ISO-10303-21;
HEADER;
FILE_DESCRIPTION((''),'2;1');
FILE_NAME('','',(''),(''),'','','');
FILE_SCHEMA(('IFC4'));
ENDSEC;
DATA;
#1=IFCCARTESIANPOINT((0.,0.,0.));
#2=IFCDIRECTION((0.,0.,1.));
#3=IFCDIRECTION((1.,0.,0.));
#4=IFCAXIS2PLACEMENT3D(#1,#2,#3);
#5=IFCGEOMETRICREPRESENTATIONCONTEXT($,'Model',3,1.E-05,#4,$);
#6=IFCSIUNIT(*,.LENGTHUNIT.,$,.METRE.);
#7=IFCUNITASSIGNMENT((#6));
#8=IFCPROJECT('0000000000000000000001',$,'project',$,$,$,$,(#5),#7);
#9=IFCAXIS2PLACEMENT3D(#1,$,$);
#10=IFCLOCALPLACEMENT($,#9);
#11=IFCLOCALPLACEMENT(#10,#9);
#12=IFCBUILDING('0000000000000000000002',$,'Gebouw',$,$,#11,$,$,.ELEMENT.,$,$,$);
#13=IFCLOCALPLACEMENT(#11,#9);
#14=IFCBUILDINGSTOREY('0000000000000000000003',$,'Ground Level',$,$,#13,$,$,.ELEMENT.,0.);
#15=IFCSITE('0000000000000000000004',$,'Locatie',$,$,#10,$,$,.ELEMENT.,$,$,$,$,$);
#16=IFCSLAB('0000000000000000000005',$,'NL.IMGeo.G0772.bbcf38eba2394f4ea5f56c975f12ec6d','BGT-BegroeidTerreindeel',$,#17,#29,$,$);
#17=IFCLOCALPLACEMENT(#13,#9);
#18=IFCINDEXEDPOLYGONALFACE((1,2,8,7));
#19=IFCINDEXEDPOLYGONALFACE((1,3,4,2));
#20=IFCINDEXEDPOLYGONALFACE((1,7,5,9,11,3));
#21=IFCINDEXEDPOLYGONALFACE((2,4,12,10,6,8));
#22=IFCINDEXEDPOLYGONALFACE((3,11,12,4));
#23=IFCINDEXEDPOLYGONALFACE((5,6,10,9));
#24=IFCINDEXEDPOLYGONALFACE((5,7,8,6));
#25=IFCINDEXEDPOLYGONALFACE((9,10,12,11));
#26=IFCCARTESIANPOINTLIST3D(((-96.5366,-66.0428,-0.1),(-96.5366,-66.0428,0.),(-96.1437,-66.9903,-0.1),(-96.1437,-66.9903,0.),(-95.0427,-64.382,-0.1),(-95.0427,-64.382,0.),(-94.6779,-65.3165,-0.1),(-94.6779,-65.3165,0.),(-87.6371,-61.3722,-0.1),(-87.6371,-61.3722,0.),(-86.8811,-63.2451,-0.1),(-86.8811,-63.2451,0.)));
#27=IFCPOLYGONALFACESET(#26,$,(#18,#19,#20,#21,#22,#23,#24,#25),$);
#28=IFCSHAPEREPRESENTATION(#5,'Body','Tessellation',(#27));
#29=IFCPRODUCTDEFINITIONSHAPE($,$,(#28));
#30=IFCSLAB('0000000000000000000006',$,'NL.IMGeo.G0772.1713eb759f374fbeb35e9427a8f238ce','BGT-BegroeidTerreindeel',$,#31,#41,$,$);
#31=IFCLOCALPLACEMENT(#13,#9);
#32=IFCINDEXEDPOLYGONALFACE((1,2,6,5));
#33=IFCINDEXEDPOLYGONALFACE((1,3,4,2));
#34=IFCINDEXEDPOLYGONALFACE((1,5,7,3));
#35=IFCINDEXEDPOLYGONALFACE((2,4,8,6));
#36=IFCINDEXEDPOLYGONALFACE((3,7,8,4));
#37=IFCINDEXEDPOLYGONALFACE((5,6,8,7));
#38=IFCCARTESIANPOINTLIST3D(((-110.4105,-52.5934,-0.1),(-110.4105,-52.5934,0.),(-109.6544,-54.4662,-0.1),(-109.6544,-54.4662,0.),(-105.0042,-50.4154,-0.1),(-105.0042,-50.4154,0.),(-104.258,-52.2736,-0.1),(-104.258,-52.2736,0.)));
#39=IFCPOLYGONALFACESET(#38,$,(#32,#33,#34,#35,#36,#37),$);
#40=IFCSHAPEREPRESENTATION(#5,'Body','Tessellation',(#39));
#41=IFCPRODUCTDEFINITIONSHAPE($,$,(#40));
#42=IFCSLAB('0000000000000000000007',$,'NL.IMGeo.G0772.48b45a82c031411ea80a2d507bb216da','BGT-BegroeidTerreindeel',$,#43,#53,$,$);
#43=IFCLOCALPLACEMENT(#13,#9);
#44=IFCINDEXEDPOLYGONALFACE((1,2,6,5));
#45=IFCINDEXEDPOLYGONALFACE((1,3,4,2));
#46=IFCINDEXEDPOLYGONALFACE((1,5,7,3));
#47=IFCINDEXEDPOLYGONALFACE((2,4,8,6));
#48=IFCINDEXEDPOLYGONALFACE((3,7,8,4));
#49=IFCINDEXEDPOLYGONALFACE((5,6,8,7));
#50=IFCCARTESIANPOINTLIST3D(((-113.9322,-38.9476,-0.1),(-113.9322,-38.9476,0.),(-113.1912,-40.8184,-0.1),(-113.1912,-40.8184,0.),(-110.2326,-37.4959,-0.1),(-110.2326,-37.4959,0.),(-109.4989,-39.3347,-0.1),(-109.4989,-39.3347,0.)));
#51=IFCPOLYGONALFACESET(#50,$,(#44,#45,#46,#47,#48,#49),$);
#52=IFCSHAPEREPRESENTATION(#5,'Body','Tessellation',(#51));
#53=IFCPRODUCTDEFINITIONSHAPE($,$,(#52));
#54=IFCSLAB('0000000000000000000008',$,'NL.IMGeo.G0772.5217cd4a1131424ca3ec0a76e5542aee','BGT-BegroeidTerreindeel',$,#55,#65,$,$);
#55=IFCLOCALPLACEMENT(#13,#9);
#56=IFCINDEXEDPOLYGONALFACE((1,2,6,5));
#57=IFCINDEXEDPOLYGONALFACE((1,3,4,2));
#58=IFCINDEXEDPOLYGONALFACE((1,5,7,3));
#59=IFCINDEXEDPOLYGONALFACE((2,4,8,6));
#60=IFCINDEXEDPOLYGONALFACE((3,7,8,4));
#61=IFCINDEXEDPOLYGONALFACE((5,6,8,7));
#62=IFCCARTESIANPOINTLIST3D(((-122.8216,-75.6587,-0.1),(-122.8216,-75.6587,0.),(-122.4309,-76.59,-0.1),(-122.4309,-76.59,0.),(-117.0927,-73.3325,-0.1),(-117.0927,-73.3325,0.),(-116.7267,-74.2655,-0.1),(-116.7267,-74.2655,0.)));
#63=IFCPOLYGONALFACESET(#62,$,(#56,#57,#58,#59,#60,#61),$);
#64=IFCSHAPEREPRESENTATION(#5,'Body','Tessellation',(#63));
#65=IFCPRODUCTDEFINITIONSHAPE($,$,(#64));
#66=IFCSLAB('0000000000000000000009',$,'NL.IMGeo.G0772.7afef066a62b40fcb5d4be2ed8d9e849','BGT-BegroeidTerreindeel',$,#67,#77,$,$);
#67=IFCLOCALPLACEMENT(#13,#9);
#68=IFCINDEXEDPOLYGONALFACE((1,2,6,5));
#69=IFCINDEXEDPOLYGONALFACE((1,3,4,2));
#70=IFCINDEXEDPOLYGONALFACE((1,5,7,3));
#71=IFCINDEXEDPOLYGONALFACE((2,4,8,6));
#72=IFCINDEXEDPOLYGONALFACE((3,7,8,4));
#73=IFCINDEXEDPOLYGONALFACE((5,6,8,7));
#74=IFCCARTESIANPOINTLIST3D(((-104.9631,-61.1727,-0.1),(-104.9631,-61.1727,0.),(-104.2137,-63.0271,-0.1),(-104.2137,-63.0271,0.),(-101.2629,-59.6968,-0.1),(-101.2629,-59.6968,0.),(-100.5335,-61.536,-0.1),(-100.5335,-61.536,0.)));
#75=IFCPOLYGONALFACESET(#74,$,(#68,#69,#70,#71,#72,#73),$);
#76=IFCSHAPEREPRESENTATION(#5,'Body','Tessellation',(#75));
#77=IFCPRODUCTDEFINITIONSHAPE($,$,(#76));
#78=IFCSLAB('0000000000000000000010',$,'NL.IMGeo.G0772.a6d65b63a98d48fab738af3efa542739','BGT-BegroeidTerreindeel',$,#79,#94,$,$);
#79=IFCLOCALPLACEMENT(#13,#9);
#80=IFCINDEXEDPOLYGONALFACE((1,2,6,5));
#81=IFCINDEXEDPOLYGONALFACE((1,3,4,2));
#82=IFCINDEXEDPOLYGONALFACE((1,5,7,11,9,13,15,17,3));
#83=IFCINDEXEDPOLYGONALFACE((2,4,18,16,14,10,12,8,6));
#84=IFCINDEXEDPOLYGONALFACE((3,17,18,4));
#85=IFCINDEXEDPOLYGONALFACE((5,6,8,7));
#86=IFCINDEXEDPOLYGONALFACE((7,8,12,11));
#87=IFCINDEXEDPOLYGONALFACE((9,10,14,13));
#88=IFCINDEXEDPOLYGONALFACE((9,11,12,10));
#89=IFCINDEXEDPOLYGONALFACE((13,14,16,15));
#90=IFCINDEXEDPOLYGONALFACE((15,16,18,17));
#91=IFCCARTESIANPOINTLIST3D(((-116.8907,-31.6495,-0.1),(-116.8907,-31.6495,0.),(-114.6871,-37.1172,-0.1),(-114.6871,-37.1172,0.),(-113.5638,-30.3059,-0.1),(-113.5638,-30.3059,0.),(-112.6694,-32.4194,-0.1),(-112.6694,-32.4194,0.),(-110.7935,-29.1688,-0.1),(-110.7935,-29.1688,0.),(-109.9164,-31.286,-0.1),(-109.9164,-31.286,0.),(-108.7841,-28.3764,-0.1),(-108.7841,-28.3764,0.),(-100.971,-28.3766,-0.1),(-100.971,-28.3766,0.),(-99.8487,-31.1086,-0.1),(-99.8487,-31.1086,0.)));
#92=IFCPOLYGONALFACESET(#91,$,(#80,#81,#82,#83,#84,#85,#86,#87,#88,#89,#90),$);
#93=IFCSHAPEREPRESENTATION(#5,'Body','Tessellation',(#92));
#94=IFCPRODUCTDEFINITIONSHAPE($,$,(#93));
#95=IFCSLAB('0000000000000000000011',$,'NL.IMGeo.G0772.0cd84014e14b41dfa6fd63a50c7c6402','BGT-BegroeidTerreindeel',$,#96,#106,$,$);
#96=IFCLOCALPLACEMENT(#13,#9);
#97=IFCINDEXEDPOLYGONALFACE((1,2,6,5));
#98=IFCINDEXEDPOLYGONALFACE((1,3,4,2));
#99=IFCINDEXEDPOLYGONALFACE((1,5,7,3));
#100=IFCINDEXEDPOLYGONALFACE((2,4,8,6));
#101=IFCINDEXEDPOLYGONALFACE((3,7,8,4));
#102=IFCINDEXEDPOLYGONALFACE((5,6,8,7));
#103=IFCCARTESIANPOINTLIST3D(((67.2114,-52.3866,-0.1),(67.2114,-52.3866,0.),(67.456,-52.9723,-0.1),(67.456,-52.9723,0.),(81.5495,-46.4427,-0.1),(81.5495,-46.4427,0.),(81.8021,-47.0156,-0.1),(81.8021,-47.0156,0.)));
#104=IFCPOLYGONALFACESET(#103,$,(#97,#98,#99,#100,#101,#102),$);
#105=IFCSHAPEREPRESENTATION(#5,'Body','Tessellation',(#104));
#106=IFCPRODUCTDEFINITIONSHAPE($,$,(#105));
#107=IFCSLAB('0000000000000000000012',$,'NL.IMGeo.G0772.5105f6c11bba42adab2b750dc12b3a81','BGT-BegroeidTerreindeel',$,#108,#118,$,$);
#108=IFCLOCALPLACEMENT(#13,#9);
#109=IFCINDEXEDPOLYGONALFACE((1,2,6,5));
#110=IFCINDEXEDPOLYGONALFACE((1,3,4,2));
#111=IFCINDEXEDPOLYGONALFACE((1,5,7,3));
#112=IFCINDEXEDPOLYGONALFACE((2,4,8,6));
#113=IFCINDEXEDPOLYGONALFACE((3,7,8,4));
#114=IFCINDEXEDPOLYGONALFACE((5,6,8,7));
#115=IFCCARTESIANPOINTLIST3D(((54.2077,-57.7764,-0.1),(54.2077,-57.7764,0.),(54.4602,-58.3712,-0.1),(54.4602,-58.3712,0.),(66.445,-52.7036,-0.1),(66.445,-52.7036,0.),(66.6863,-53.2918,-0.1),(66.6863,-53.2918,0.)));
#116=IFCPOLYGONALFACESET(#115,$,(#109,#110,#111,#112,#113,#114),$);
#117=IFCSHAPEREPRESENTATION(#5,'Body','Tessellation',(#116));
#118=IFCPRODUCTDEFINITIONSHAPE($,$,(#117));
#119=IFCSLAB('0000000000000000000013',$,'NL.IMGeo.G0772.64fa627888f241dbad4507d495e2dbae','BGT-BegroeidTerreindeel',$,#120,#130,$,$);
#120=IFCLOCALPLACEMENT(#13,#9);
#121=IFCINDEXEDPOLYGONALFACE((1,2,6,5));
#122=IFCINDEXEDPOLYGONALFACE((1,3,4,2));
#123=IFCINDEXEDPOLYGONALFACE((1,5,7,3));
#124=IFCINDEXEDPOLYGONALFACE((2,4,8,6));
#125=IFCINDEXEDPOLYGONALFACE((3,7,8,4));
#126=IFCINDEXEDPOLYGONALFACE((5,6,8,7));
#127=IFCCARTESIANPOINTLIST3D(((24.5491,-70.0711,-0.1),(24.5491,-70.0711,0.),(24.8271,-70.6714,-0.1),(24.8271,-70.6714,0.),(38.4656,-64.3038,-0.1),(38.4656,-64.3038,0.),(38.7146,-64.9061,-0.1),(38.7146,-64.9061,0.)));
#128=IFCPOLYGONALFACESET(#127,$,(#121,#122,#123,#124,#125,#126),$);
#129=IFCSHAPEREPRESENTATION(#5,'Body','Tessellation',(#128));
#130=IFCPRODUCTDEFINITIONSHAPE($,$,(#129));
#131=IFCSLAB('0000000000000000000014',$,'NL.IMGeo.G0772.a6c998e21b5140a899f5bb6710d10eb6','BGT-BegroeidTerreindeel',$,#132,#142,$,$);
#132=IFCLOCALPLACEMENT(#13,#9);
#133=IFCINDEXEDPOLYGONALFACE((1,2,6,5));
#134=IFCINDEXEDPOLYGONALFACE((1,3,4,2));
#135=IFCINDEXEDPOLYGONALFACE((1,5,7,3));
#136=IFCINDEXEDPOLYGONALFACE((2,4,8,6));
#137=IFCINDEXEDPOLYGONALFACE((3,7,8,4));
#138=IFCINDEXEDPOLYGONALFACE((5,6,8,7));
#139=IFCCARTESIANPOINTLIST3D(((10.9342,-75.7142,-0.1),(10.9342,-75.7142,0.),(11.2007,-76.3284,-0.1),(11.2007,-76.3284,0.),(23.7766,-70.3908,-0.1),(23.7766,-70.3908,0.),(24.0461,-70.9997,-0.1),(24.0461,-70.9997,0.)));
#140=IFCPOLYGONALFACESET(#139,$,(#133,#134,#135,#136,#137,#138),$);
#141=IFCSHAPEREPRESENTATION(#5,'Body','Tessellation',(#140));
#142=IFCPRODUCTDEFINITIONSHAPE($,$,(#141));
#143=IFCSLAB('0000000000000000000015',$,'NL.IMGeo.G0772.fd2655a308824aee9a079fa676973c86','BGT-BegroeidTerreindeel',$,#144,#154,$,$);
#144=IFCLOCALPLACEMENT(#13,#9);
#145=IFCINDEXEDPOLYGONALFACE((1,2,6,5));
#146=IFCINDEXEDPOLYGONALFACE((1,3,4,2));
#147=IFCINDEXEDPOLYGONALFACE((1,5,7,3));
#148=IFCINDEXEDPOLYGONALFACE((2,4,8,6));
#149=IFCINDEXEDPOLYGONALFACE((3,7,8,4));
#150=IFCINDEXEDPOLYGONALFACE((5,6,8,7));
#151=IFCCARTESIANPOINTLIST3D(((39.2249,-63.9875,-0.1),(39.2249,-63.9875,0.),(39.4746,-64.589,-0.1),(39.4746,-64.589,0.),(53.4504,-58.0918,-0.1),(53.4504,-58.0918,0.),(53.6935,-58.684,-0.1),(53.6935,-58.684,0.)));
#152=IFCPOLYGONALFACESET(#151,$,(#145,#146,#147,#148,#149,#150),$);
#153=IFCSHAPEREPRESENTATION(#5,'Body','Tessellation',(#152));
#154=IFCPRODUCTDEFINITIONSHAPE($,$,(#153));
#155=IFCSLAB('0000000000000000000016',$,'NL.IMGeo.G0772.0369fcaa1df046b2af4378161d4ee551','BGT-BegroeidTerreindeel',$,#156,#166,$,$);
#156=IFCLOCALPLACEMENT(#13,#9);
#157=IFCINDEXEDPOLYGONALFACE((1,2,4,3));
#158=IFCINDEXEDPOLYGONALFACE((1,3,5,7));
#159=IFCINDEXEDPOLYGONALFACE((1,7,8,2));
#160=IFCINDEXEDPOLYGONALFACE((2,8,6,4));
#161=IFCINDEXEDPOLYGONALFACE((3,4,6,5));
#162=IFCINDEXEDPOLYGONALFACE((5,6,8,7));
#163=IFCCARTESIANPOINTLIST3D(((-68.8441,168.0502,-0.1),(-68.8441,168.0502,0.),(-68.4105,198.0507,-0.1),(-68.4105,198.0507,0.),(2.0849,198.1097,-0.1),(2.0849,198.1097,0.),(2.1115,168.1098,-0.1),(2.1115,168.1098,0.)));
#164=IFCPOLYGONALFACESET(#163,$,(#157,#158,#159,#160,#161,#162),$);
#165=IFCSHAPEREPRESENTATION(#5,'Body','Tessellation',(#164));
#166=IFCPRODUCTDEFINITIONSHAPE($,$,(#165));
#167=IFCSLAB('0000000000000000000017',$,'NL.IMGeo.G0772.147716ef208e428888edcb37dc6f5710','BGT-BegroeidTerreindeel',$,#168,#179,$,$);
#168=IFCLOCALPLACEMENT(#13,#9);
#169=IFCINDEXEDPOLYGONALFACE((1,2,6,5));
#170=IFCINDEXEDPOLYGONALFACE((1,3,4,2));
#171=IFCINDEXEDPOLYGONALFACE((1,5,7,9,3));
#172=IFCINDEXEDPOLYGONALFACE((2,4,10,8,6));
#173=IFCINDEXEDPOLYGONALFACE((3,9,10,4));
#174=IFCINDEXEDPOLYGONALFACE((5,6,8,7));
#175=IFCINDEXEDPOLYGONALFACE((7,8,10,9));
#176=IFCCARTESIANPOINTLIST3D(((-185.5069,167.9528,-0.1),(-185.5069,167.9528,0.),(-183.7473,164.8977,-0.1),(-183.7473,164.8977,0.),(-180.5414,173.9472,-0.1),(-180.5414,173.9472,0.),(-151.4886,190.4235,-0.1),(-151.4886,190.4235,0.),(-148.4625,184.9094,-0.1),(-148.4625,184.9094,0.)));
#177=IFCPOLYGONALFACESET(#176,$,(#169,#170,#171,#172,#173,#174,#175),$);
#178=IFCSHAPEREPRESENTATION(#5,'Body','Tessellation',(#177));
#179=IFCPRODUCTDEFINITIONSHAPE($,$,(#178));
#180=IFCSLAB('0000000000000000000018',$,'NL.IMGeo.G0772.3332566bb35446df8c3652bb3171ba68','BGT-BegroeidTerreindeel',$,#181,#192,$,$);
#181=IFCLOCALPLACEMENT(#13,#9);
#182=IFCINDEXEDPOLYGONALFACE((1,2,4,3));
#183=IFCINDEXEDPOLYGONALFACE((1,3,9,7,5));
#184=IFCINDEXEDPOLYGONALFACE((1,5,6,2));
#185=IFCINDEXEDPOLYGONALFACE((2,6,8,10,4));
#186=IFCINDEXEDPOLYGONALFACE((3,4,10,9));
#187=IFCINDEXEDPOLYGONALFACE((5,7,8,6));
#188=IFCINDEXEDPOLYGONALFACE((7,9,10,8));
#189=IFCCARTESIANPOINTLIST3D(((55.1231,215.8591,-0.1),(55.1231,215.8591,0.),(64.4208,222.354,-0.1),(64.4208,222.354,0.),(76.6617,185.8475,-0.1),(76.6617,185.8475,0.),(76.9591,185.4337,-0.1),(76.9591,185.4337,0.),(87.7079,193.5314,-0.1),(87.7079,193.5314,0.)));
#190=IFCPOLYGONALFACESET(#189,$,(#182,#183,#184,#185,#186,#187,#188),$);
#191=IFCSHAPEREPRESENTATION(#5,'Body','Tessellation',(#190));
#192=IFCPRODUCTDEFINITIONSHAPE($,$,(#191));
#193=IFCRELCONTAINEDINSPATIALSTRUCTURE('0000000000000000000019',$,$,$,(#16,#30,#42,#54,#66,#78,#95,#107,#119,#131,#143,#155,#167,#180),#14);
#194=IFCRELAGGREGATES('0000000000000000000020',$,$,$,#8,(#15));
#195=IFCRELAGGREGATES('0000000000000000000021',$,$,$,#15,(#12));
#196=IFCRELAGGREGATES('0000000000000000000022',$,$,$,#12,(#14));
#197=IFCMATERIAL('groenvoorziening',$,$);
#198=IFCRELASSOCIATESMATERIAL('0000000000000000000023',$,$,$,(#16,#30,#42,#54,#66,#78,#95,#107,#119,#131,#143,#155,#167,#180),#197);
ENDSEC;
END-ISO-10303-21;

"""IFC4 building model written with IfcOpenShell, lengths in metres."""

from ifc_helpers import new_model, si_unit, frame, origin, origin_with_axes, place, context, project, spatial, polyline, outline, extrude, material, element, save


model = new_model("IFC4")

# Units and contexts
model_context = context("Model", 3, precision=1e-05, world=origin_with_axes())
ifc_project = project(units=[si_unit("LENGTHUNIT", "METRE")], contexts=[model_context])

# Site, building, storey
site_placement = place(None, origin())
site = spatial("IfcSite", under=ifc_project, at=site_placement, Name="Locatie", CompositionType="ELEMENT")
building_placement = place(site_placement, origin())
building = spatial("IfcBuilding", under=site, at=building_placement, Name="Gebouw", CompositionType="ELEMENT")
storey_placement = place(building_placement, origin())
storey = spatial("IfcBuildingStorey", under=building, at=storey_placement, Name="Ground Level", CompositionType="ELEMENT", Elevation=0.0)

# Slabs
ifc_material = material(Name="groenvoorziening")
slab_1_placement = place(storey_placement, origin())
element("IfcSlab", 1, at=slab_1_placement, inside=storey, material=ifc_material, Name="NL.IMGeo.G0772.bbcf38eba2394f4ea5f56c975f12ec6d", Description="BGT-BegroeidTerreindeel", context=model_context, shape_type="SweptSolid", body=[
    extrude(outline(polyline([(-96.5366, -66.0428), (-94.6779, -65.3165), (-95.0427, -64.382), (-87.6371, -61.3722), (-86.8811, -63.2451), (-96.1437, -66.9903), (-96.5366, -66.0428)])), frame((0.0, 0.0, -0.1), z_axis=(0.0, 0.0, 1.0), x_axis=(1.0, 0.0, 0.0)), (0.0, 0.0, 1.0), 0.1),
])
slab_2_placement = place(storey_placement, origin())
element("IfcSlab", 2, at=slab_2_placement, inside=storey, material=ifc_material, Name="NL.IMGeo.G0772.1713eb759f374fbeb35e9427a8f238ce", Description="BGT-BegroeidTerreindeel", context=model_context, shape_type="SweptSolid", body=[
    extrude(outline(polyline([(-109.6544, -54.4662), (-110.4105, -52.5934), (-105.0042, -50.4154), (-104.258, -52.2736), (-109.6544, -54.4662)])), frame((0.0, 0.0, -0.1), z_axis=(0.0, 0.0, 1.0), x_axis=(1.0, 0.0, 0.0)), (0.0, 0.0, 1.0), 0.1),
])
slab_3_placement = place(storey_placement, origin())
element("IfcSlab", 3, at=slab_3_placement, inside=storey, material=ifc_material, Name="NL.IMGeo.G0772.48b45a82c031411ea80a2d507bb216da", Description="BGT-BegroeidTerreindeel", context=model_context, shape_type="SweptSolid", body=[
    extrude(outline(polyline([(-113.1912, -40.8184), (-113.9322, -38.9476), (-110.2326, -37.4959), (-109.4989, -39.3347), (-113.1912, -40.8184)])), frame((0.0, 0.0, -0.1), z_axis=(0.0, 0.0, 1.0), x_axis=(1.0, 0.0, 0.0)), (0.0, 0.0, 1.0), 0.1),
])
slab_4_placement = place(storey_placement, origin())
element("IfcSlab", 4, at=slab_4_placement, inside=storey, material=ifc_material, Name="NL.IMGeo.G0772.5217cd4a1131424ca3ec0a76e5542aee", Description="BGT-BegroeidTerreindeel", context=model_context, shape_type="SweptSolid", body=[
    extrude(outline(polyline([(-117.0927, -73.3325), (-116.7267, -74.2655), (-122.4309, -76.59), (-122.8216, -75.6587), (-117.0927, -73.3325)])), frame((0.0, 0.0, -0.1), z_axis=(0.0, 0.0, 1.0), x_axis=(1.0, 0.0, 0.0)), (0.0, 0.0, 1.0), 0.1),
])
slab_5_placement = place(storey_placement, origin())
element("IfcSlab", 5, at=slab_5_placement, inside=storey, material=ifc_material, Name="NL.IMGeo.G0772.7afef066a62b40fcb5d4be2ed8d9e849", Description="BGT-BegroeidTerreindeel", context=model_context, shape_type="SweptSolid", body=[
    extrude(outline(polyline([(-104.2137, -63.0271), (-104.9631, -61.1727), (-101.2629, -59.6968), (-100.5335, -61.536), (-104.2137, -63.0271)])), frame((0.0, 0.0, -0.1), z_axis=(0.0, 0.0, 1.0), x_axis=(1.0, 0.0, 0.0)), (0.0, 0.0, 1.0), 0.1),
])
slab_6_placement = place(storey_placement, origin())
element("IfcSlab", 6, at=slab_6_placement, inside=storey, material=ifc_material, Name="NL.IMGeo.G0772.a6d65b63a98d48fab738af3efa542739", Description="BGT-BegroeidTerreindeel", context=model_context, shape_type="SweptSolid", body=[
    extrude(outline(polyline([(-116.8907, -31.6495), (-113.5638, -30.3059), (-112.6694, -32.4194), (-109.9164, -31.286), (-110.7935, -29.1688), (-108.7841, -28.3764), (-100.971, -28.3766), (-99.8487, -31.1086), (-114.6871, -37.1172), (-116.8907, -31.6495)])), frame((0.0, 0.0, -0.1), z_axis=(0.0, 0.0, 1.0), x_axis=(1.0, 0.0, 0.0)), (0.0, 0.0, 1.0), 0.1),
])
slab_7_placement = place(storey_placement, origin())
element("IfcSlab", 7, at=slab_7_placement, inside=storey, material=ifc_material, Name="NL.IMGeo.G0772.0cd84014e14b41dfa6fd63a50c7c6402", Description="BGT-BegroeidTerreindeel", context=model_context, shape_type="SweptSolid", body=[
    extrude(outline(polyline([(81.8021, -47.0156), (67.456, -52.9723), (67.2114, -52.3866), (81.5495, -46.4427), (81.8021, -47.0156)])), frame((0.0, 0.0, -0.1), z_axis=(0.0, 0.0, 1.0), x_axis=(1.0, 0.0, 0.0)), (0.0, 0.0, 1.0), 0.1),
])
slab_8_placement = place(storey_placement, origin())
element("IfcSlab", 8, at=slab_8_placement, inside=storey, material=ifc_material, Name="NL.IMGeo.G0772.5105f6c11bba42adab2b750dc12b3a81", Description="BGT-BegroeidTerreindeel", context=model_context, shape_type="SweptSolid", body=[
    extrude(outline(polyline([(66.6863, -53.2918), (54.4602, -58.3712), (54.2077, -57.7764), (66.445, -52.7036), (66.6863, -53.2918)])), frame((0.0, 0.0, -0.1), z_axis=(0.0, 0.0, 1.0), x_axis=(1.0, 0.0, 0.0)), (0.0, 0.0, 1.0), 0.1),
])
slab_9_placement = place(storey_placement, origin())
element("IfcSlab", 9, at=slab_9_placement, inside=storey, material=ifc_material, Name="NL.IMGeo.G0772.64fa627888f241dbad4507d495e2dbae", Description="BGT-BegroeidTerreindeel", context=model_context, shape_type="SweptSolid", body=[
    extrude(outline(polyline([(38.7146, -64.9061), (24.8271, -70.6714), (24.5491, -70.0711), (38.4656, -64.3038), (38.7146, -64.9061)])), frame((0.0, 0.0, -0.1), z_axis=(0.0, 0.0, 1.0), x_axis=(1.0, 0.0, 0.0)), (0.0, 0.0, 1.0), 0.1),
])
slab_10_placement = place(storey_placement, origin())
element("IfcSlab", 10, at=slab_10_placement, inside=storey, material=ifc_material, Name="NL.IMGeo.G0772.a6c998e21b5140a899f5bb6710d10eb6", Description="BGT-BegroeidTerreindeel", context=model_context, shape_type="SweptSolid", body=[
    extrude(outline(polyline([(24.0461, -70.9997), (11.2007, -76.3284), (10.9342, -75.7142), (23.7766, -70.3908), (24.0461, -70.9997)])), frame((0.0, 0.0, -0.1), z_axis=(0.0, 0.0, 1.0), x_axis=(1.0, 0.0, 0.0)), (0.0, 0.0, 1.0), 0.1),
])
slab_11_placement = place(storey_placement, origin())
element("IfcSlab", 11, at=slab_11_placement, inside=storey, material=ifc_material, Name="NL.IMGeo.G0772.fd2655a308824aee9a079fa676973c86", Description="BGT-BegroeidTerreindeel", context=model_context, shape_type="SweptSolid", body=[
    extrude(outline(polyline([(53.6935, -58.684), (39.4746, -64.589), (39.2249, -63.9875), (53.4504, -58.0918), (53.6935, -58.684)])), frame((0.0, 0.0, -0.1), z_axis=(0.0, 0.0, 1.0), x_axis=(1.0, 0.0, 0.0)), (0.0, 0.0, 1.0), 0.1),
])
slab_12_placement = place(storey_placement, origin())
element("IfcSlab", 12, at=slab_12_placement, inside=storey, material=ifc_material, Name="NL.IMGeo.G0772.0369fcaa1df046b2af4378161d4ee551", Description="BGT-BegroeidTerreindeel", context=model_context, shape_type="SweptSolid", body=[
    extrude(outline(polyline([(2.1115, 168.1098), (-68.8441, 168.0502), (-68.4105, 198.0507), (2.0849, 198.1097), (2.1115, 168.1098)])), frame((0.0, 0.0, -0.1), z_axis=(0.0, 0.0, 1.0), x_axis=(1.0, 0.0, 0.0)), (0.0, 0.0, 1.0), 0.1),
])
slab_13_placement = place(storey_placement, origin())
element("IfcSlab", 13, at=slab_13_placement, inside=storey, material=ifc_material, Name="NL.IMGeo.G0772.147716ef208e428888edcb37dc6f5710", Description="BGT-BegroeidTerreindeel", context=model_context, shape_type="SweptSolid", body=[
    extrude(outline(polyline([(-151.4886, 190.4235), (-148.4625, 184.9094), (-183.7473, 164.8977), (-185.5069, 167.9528), (-180.5414, 173.9472), (-151.4886, 190.4235)])), frame((0.0, 0.0, -0.1), z_axis=(0.0, 0.0, 1.0), x_axis=(1.0, 0.0, 0.0)), (0.0, 0.0, 1.0), 0.1),
])
slab_14_placement = place(storey_placement, origin())
element("IfcSlab", 14, at=slab_14_placement, inside=storey, material=ifc_material, Name="NL.IMGeo.G0772.3332566bb35446df8c3652bb3171ba68", Description="BGT-BegroeidTerreindeel", context=model_context, shape_type="SweptSolid", body=[
    extrude(outline(polyline([(76.9591, 185.4337), (76.6617, 185.8475), (55.1231, 215.8591), (64.4208, 222.354), (87.7079, 193.5314), (76.9591, 185.4337)])), frame((0.0, 0.0, -0.1), z_axis=(0.0, 0.0, 1.0), x_axis=(1.0, 0.0, 0.0)), (0.0, 0.0, 1.0), 0.1),
])

save(model, "model.ifc")
